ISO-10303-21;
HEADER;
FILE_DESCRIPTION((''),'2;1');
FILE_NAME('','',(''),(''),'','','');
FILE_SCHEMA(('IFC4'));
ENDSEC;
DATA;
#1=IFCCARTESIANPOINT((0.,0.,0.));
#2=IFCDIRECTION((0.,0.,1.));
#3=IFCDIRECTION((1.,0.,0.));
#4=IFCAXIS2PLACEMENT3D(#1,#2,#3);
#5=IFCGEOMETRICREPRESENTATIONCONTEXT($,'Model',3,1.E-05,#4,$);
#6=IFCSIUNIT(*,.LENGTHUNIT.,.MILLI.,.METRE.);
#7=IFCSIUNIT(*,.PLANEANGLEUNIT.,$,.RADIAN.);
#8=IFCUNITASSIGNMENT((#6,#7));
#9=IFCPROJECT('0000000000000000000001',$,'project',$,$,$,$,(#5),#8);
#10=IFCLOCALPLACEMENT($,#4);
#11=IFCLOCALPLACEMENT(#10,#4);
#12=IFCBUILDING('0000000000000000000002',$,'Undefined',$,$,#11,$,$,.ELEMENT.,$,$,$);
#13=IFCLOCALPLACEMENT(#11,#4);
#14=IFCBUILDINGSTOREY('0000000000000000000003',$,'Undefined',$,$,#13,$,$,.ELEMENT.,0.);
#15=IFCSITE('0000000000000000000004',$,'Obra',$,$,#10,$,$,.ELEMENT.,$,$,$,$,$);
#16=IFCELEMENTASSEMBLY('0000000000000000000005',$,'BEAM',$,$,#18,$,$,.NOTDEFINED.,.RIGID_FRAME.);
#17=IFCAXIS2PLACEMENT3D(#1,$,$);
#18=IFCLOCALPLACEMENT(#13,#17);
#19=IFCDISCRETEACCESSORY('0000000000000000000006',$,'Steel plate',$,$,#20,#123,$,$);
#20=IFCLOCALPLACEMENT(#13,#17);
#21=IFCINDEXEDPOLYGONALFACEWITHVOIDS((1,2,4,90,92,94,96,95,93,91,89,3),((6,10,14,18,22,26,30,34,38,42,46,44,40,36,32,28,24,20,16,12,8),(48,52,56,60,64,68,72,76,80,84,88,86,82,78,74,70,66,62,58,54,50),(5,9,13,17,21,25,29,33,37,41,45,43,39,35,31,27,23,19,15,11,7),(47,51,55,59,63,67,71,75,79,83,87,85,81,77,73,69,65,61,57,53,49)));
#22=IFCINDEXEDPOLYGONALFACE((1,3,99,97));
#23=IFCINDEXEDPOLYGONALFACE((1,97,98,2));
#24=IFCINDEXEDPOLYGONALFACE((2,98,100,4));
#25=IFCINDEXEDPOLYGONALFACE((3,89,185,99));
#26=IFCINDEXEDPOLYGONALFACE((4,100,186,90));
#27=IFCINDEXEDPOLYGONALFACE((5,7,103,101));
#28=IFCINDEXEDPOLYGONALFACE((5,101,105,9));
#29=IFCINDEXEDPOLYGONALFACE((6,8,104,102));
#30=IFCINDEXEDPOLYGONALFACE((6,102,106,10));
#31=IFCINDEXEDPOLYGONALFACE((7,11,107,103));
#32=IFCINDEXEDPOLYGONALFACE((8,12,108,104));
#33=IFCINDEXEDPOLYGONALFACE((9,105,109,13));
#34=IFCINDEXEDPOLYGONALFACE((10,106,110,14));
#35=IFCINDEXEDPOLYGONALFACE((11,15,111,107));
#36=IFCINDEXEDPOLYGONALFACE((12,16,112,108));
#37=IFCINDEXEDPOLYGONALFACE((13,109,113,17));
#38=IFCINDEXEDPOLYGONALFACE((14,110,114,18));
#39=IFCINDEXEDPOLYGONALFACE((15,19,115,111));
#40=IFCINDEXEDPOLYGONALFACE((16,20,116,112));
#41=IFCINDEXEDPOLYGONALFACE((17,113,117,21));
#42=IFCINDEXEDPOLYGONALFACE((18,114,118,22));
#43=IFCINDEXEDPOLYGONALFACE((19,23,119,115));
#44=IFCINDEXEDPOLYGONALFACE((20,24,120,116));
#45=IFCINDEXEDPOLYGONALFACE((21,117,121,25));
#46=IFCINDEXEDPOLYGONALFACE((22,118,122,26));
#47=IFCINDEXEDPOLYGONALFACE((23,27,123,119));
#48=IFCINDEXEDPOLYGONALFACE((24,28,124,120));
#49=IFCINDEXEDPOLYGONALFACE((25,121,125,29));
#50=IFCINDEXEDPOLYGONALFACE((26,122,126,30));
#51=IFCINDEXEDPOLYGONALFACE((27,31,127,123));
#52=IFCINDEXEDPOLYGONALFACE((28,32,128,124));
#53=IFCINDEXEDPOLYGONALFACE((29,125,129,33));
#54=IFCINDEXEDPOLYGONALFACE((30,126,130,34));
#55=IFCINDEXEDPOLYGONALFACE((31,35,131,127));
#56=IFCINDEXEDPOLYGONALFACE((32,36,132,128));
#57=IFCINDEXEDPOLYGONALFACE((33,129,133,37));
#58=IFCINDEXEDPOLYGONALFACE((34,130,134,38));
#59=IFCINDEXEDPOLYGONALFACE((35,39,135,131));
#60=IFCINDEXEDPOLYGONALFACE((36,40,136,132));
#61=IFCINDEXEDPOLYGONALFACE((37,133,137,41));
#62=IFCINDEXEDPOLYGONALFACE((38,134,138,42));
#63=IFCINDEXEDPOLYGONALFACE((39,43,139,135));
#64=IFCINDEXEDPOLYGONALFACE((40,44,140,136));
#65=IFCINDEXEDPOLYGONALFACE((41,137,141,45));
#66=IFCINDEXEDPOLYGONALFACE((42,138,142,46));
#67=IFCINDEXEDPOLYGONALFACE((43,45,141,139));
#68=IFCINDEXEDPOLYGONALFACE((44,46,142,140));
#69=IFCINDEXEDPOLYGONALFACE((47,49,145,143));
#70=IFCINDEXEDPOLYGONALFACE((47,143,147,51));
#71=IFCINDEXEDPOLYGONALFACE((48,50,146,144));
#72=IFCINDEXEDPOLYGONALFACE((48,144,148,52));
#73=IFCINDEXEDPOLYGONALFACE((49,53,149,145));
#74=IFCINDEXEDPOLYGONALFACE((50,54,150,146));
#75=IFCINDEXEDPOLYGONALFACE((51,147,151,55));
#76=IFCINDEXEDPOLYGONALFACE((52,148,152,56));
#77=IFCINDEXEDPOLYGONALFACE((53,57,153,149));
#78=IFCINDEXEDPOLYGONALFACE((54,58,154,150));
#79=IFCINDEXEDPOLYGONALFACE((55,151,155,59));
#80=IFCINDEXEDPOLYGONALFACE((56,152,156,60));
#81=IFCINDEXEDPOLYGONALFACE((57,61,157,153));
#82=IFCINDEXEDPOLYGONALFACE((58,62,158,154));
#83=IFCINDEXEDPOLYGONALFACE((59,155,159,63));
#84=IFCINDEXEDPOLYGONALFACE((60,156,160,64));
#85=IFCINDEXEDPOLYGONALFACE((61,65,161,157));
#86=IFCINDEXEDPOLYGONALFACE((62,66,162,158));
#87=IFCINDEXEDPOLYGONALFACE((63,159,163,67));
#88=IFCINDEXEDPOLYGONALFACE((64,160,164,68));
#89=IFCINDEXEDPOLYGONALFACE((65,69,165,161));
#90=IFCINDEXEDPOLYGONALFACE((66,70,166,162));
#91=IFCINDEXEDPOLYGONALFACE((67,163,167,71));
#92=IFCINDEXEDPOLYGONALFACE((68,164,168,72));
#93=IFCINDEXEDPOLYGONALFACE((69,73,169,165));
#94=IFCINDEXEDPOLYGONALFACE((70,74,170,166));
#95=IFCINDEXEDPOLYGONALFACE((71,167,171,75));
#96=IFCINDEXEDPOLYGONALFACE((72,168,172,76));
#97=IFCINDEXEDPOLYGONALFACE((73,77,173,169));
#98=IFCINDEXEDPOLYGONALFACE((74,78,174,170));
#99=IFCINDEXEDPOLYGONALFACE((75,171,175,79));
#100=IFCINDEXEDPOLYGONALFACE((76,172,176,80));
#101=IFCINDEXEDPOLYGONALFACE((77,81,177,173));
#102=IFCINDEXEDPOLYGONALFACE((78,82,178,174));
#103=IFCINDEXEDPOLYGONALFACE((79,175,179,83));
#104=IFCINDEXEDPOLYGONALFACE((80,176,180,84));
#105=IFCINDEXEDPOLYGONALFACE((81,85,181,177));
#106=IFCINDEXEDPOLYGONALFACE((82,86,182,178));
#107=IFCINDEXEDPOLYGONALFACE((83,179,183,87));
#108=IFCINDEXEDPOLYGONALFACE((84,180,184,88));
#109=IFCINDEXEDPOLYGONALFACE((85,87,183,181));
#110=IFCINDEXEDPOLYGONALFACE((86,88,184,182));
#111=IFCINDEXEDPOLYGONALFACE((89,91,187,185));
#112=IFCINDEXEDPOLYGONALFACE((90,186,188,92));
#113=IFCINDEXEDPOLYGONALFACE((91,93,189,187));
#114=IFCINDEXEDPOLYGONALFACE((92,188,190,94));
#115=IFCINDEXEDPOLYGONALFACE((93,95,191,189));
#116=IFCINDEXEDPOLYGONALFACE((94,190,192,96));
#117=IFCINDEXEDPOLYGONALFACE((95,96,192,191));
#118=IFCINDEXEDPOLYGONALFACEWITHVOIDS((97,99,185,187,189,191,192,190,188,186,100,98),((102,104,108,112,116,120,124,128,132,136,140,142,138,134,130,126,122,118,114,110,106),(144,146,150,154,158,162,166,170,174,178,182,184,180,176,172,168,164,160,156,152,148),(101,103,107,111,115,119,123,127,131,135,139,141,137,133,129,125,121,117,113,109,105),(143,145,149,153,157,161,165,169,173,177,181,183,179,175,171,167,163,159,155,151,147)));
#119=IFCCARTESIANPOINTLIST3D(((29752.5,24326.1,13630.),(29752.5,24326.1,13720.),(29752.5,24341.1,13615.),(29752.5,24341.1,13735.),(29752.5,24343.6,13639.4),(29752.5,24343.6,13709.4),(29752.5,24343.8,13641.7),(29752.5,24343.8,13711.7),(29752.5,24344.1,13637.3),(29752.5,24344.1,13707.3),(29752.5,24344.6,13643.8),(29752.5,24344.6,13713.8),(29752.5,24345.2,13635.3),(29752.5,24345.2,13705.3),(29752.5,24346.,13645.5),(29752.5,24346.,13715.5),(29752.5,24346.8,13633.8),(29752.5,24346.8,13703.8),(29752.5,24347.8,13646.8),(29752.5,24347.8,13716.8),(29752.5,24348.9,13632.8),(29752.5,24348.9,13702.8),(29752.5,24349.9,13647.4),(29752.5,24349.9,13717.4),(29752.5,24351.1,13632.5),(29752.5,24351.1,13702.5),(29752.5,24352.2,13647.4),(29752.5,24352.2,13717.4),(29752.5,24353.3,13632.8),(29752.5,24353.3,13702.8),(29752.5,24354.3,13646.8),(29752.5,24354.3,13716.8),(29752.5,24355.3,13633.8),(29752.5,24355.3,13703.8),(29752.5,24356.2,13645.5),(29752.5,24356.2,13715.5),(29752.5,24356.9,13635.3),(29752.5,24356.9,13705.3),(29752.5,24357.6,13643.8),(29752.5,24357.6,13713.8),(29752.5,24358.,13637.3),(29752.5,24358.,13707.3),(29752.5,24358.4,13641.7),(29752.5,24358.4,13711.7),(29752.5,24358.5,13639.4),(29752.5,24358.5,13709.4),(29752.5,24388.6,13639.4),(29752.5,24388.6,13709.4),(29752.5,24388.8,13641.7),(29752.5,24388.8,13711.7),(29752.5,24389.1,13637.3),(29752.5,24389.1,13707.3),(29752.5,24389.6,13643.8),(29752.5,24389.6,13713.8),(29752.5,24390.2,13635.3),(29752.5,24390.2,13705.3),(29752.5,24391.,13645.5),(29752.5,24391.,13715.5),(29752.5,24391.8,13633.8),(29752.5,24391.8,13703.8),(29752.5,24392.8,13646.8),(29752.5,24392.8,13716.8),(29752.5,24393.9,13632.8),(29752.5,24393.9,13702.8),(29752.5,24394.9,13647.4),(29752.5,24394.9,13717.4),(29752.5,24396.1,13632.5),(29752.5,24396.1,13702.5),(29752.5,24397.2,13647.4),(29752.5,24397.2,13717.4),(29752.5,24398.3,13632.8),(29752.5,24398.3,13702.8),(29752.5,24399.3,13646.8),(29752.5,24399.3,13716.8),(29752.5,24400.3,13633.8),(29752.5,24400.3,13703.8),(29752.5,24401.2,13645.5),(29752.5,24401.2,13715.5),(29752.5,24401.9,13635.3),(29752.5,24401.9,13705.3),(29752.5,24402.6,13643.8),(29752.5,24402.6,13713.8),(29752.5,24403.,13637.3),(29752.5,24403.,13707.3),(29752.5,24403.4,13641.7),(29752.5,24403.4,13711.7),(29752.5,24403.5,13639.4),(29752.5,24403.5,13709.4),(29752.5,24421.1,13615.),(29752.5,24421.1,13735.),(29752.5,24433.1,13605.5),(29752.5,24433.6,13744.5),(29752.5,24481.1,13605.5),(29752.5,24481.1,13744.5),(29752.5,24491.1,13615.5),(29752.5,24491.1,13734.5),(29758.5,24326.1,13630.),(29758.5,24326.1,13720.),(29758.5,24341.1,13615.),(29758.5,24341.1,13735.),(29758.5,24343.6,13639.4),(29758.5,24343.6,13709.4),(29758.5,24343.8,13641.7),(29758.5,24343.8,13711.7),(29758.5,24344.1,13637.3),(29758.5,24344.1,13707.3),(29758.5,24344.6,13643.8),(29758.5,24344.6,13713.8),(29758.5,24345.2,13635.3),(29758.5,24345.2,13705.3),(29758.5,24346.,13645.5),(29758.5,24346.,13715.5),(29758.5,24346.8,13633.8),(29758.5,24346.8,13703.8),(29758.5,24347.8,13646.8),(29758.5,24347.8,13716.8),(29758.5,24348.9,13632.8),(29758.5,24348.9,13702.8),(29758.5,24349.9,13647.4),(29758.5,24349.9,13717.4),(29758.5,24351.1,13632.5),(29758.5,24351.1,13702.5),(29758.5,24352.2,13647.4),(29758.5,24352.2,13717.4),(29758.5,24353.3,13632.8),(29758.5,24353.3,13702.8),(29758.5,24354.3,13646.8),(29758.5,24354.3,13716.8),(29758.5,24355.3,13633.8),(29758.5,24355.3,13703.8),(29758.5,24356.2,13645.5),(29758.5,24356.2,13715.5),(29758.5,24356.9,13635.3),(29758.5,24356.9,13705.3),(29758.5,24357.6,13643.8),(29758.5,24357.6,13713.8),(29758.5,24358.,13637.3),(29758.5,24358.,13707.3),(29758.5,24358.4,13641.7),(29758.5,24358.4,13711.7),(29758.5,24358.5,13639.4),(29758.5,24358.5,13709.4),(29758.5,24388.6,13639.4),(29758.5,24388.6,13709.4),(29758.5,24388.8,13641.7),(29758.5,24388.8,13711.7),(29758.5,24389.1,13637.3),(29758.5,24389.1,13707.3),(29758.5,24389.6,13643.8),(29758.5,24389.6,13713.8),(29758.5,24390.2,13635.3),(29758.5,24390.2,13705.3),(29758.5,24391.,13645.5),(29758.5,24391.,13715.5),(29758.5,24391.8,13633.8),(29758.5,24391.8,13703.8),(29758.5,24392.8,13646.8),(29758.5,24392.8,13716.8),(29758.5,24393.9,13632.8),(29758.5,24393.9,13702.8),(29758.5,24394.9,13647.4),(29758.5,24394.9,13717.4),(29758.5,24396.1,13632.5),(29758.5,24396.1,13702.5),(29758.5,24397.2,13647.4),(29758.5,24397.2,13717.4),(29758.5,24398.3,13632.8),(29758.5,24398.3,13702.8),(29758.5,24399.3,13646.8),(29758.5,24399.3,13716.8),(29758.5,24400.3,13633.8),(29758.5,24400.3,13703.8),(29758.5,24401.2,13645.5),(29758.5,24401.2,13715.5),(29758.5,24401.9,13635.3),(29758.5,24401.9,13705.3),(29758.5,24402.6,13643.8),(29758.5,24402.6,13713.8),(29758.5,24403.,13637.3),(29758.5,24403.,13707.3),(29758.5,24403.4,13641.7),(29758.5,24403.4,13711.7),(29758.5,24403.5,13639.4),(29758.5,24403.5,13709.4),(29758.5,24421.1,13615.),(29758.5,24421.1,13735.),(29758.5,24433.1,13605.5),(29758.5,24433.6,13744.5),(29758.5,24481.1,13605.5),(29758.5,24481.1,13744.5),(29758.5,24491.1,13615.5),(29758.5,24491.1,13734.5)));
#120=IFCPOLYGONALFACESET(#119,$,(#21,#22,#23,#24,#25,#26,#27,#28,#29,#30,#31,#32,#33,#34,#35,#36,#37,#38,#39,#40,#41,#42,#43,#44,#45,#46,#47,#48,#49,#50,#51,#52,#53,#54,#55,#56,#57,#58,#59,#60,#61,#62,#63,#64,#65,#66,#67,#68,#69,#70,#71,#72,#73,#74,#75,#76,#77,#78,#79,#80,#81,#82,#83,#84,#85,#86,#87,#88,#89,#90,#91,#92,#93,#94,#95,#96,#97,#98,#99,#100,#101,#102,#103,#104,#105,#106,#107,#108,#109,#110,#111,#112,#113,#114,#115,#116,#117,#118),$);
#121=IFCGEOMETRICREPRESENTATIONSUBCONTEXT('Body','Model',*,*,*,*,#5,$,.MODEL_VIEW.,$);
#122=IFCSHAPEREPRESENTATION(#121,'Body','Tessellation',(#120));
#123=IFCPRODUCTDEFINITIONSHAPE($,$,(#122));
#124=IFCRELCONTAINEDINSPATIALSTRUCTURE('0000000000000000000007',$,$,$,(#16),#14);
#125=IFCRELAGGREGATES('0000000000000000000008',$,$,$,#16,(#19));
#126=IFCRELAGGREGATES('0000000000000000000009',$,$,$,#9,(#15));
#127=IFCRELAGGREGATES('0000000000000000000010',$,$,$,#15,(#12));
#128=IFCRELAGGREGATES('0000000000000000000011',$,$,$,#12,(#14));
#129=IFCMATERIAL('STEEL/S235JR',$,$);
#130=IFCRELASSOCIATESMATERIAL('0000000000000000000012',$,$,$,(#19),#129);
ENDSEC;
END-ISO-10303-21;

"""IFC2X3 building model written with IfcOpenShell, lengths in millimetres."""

from ifc_helpers import new_model, si_unit, frame, origin_with_axes, origin_2d_with_axis, place, context, subcontext, project, spatial, polyline, circle, outline, extrude, source, transform, mapped, material, element, aggregate, save


model = new_model("IFC2X3")

# Units and contexts
model_context = context("Model", 3, precision=1e-05, world=origin_with_axes())
body_context = subcontext(model_context, "Body", "Model", "MODEL_VIEW")
ifc_project = project(units=[si_unit("LENGTHUNIT", "METRE", prefix="MILLI"), si_unit("PLANEANGLEUNIT", "RADIAN")], contexts=[model_context])

# Site, building, storey
site_placement = place(None, origin_with_axes())
site = spatial("IfcSite", under=ifc_project, at=site_placement, Name="Obra", CompositionType="ELEMENT")
building_placement = place(site_placement, origin_with_axes())
building = spatial("IfcBuilding", under=site, at=building_placement, Name="Undefined", CompositionType="ELEMENT")
storey_placement = place(building_placement, origin_with_axes())
storey = spatial("IfcBuildingStorey", under=building, at=storey_placement, Name="Undefined", CompositionType="ELEMENT", Elevation=0.0)

# Shared definitions
ifc_material_1 = material(Name="STEEL/S235JR")

# Element assembly, discrete accessory, opening
assembly_1_placement = place(storey_placement, origin_with_axes())
assembly_1 = element("IfcElementAssembly", 1, at=assembly_1_placement, inside=storey, Name="BEAM", AssemblyPlace="NOTDEFINED", PredefinedType="RIGID_FRAME")
shared_shape_1 = source(origin_with_axes(), body_context, "Body", "SweptSolid", [
    extrude(circle(Radius=7.5, at=origin_2d_with_axis()), frame((0.0, 2.4, 0.0), z_axis=(0.0, 1.0, 0.0), x_axis=(1.0, 0.0, 0.0)), (0.0, 0.0, 1.0), 6.2),
])
discrete_accessory_1_placement = place(assembly_1_placement, frame((29755.5, 24491.1, 13615.5), z_axis=(-1.0, 0.0, 0.0), x_axis=(0.000001, -0.707107, -0.707107)))
discrete_accessory_1 = element("IfcDiscreteAccessory", 2, at=discrete_accessory_1_placement, material=ifc_material_1, Name="Steel plate", context=body_context, shape_type="SweptSolid", body=[
    extrude(outline(polyline([(0.0, 0.0), (14.1, 0.0), (48.1, 33.9), (49.9, 49.1), (106.4, 105.7), (106.4, 126.9), (42.8, 190.6), (21.6, 190.6), (-35.0, 134.0), (-50.6, 131.9), (-84.1, 98.3), (-84.1, 84.1), (0.0, 0.0)])), frame((0.0, 0.0, -3.0), z_axis=(0.0, 0.0, 1.0), x_axis=(1.0, 0.0, 0.0)), (0.0, 0.0, 1.0), 6.0),
])
opening_1_placement = place(assembly_1_placement, frame((29750.0, 24373.6, 13710.0), z_axis=(0.0, -1.0, 0.0), x_axis=(0.0, 0.0, -1.0)))
element("IfcOpeningElement", 3, at=opening_1_placement, cuts=discrete_accessory_1, ObjectType="Opening", context=body_context, shape_type="MappedRepresentation", body=[
    mapped(shared_shape_1, transform((0.0, 0.0, -22.5))),
    mapped(shared_shape_1, transform((70.0, 0.0, -22.5))),
    mapped(shared_shape_1, transform((0.0, 0.0, 22.5))),
    mapped(shared_shape_1, transform((70.0, 0.0, 22.5))),
])

aggregate(assembly_1, [discrete_accessory_1])

save(model, "model.ifc")
